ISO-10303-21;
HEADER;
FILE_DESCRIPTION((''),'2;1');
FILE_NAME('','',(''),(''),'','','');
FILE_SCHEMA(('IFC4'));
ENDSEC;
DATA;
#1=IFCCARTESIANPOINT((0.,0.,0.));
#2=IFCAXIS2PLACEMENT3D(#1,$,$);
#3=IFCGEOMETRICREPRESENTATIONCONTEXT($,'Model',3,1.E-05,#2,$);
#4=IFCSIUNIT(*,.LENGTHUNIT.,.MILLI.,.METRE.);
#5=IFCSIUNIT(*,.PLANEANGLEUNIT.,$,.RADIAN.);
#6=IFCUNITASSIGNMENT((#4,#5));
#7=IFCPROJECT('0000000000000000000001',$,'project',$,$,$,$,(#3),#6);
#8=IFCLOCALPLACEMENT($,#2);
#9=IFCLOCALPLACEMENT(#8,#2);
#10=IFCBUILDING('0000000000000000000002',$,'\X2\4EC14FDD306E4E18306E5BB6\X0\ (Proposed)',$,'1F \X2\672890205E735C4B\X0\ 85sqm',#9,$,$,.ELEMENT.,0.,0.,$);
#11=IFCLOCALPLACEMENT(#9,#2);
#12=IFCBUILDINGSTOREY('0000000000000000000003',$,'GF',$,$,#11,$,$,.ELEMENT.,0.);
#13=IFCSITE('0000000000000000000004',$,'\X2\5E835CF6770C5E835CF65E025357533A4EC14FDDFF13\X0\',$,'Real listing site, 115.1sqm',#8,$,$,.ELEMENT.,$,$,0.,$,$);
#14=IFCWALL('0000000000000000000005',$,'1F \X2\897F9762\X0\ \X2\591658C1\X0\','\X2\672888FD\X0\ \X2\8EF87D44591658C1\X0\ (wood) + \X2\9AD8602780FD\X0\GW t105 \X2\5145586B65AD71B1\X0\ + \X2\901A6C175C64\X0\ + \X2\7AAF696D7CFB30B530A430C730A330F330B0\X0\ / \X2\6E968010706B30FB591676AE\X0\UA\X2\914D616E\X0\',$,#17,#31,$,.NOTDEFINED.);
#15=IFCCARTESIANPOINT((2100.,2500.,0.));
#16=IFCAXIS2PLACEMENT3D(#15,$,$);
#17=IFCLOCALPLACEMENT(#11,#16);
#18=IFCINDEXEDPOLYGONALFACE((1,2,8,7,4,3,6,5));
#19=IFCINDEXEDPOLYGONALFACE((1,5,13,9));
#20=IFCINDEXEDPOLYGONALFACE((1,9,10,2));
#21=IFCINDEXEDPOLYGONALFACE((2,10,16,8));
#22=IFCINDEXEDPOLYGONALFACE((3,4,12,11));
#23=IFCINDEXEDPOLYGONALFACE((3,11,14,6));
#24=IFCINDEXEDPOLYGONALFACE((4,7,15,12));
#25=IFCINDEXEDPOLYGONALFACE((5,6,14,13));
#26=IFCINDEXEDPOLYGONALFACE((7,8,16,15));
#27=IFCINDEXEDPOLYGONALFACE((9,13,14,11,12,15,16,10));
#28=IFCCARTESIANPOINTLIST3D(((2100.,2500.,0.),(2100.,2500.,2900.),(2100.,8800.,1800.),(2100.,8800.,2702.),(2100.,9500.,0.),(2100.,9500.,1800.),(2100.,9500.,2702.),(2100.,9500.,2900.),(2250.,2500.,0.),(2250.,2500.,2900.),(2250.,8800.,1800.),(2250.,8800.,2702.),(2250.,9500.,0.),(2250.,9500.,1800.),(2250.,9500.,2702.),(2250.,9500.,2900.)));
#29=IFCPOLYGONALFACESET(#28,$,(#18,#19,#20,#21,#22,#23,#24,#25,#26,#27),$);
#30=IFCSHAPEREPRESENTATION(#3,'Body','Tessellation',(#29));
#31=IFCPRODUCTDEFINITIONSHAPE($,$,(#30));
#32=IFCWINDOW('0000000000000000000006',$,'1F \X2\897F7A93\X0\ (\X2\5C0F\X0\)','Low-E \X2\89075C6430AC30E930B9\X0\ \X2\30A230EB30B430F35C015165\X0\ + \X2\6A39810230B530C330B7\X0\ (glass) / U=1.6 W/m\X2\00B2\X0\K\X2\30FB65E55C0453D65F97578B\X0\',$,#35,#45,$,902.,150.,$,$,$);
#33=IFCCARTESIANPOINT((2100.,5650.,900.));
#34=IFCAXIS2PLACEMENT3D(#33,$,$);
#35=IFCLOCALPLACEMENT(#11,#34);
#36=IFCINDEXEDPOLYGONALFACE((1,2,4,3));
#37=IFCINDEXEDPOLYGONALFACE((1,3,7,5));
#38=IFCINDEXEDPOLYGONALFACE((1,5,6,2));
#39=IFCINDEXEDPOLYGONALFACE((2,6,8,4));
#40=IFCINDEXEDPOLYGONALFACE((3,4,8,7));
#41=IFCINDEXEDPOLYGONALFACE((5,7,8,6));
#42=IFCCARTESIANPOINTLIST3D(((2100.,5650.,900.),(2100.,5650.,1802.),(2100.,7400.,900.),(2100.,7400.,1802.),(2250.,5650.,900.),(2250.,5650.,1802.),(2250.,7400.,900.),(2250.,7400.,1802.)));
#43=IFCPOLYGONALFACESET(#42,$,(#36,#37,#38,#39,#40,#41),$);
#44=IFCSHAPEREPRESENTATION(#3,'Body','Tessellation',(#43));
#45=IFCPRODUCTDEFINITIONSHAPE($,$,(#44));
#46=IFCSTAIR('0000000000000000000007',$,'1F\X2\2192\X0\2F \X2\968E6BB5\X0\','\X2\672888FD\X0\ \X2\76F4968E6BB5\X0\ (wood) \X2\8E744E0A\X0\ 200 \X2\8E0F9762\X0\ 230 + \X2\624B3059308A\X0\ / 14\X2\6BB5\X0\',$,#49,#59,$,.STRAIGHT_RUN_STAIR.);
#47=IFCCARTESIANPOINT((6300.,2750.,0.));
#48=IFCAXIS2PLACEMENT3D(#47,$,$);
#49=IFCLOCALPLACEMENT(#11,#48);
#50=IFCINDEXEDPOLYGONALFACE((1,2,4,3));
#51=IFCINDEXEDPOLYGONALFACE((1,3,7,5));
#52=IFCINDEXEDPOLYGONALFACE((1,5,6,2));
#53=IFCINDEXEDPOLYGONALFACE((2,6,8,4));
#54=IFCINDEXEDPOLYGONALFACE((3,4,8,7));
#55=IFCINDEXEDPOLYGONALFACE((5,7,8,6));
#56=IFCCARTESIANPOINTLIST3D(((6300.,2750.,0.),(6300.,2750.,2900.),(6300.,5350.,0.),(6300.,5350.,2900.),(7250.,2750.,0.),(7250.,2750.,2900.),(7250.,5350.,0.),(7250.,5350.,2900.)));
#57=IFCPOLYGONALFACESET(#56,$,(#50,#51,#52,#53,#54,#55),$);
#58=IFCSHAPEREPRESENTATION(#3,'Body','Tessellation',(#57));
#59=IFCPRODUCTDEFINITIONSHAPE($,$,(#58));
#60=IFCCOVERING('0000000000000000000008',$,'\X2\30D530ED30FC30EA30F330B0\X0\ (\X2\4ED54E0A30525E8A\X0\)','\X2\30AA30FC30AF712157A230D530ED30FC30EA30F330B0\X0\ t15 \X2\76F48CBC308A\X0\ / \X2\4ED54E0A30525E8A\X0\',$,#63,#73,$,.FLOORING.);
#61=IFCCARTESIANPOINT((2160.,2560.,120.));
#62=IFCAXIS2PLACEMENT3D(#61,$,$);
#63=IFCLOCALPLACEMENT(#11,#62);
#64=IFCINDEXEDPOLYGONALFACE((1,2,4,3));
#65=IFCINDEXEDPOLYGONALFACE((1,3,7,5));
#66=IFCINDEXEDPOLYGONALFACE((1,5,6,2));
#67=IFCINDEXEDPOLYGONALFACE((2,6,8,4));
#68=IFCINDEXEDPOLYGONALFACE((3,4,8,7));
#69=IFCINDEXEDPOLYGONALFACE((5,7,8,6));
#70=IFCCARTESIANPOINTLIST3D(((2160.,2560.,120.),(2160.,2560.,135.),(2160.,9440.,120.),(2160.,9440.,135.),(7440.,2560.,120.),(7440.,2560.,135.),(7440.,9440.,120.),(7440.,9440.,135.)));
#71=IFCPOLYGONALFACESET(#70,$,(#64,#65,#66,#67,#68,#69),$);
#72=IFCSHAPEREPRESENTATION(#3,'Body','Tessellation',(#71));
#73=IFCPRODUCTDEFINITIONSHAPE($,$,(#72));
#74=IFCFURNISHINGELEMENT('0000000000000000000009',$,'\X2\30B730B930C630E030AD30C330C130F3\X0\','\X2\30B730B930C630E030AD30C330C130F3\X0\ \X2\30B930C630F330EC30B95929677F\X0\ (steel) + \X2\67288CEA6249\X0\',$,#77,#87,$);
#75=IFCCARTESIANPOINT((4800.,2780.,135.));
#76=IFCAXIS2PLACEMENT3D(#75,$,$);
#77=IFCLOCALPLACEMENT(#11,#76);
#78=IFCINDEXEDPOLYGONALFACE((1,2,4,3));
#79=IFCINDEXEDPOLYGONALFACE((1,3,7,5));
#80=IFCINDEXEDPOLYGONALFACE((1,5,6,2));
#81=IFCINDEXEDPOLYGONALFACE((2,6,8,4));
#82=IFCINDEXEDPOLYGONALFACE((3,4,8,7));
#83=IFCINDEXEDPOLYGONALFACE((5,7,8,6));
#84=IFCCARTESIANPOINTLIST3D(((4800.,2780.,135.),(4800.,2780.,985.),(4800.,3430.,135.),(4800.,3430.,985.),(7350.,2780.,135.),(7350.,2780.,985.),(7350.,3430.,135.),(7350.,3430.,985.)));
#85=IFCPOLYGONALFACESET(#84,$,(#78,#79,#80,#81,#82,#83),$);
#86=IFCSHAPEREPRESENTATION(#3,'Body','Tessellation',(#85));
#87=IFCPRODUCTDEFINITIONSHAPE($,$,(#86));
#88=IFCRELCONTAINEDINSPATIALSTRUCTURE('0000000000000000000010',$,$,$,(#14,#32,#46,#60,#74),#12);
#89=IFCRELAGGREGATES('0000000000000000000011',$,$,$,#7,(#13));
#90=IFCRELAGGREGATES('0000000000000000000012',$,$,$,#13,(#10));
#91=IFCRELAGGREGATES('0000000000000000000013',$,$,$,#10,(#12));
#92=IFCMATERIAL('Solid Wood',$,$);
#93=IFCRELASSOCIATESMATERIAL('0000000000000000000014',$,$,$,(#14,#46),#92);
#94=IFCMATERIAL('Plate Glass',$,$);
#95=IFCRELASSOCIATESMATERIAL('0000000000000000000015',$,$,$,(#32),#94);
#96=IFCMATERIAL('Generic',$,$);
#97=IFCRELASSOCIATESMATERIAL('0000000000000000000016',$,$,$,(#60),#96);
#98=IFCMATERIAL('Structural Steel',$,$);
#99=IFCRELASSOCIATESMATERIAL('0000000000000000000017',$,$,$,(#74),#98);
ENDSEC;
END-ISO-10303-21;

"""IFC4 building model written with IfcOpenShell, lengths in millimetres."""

from ifc_helpers import new_model, si_unit, frame, frame_2d, origin, place, context, project, spatial, rectangle, extrude, material, element, fill, save


model = new_model("IFC4")

# Units and contexts
model_context = context("Model", 3, precision=1e-05, world=origin())
ifc_project = project(units=[si_unit("LENGTHUNIT", "METRE", prefix="MILLI"), si_unit("PLANEANGLEUNIT", "RADIAN")], contexts=[model_context])

# Site, building, storey
site_placement = place(None, origin())
site = spatial("IfcSite", under=ifc_project, at=site_placement, Name="広島県広島市南区仁保３", ObjectType="Real listing site, 115.1sqm", CompositionType="ELEMENT", RefElevation=0.0)
building_placement = place(site_placement, origin())
building = spatial("IfcBuilding", under=site, at=building_placement, Name="仁保の丘の家 (Proposed)", ObjectType="1F 木造平屋 85sqm", CompositionType="ELEMENT", ElevationOfRefHeight=0.0, ElevationOfTerrain=0.0)
storey_placement = place(building_placement, origin())
storey = spatial("IfcBuildingStorey", under=building, at=storey_placement, Name="GF", CompositionType="ELEMENT", Elevation=0.0)

# Shared definitions
ifc_material_1 = material(Name="Solid Wood")
ifc_material_2 = material(Name="Generic")

# Shared definitions
ifc_material_3 = material(Name="Plate Glass")

# Wall, opening, window
wall_1_placement = place(storey_placement, frame((2100.0, 2500.0, 0.0)))
wall_1 = element("IfcWall", 1, at=wall_1_placement, inside=storey, material=ifc_material_1, Name="1F 西面 外壁", Description="木製 軸組外壁 (wood) + 高性能GW t105 充填断熱 + 通気層 + 窯業系サイディング / 準耐火・外皮UA配慮", PredefinedType="NOTDEFINED", context=model_context, shape_type="SweptSolid", body=[
    extrude(rectangle(XDim=150.0, YDim=7000.0, at=frame_2d((75.0, 3500.0))), frame((2100.0, 2500.0, 0.0)), (0.0, 0.0, 1.0), 2900.0),
])
opening_1_placement = place(storey_placement, frame((2100.0, 5650.0, 900.0)))
opening_1 = element("IfcOpeningElement", 2, at=opening_1_placement, cuts=wall_1, PredefinedType="NOTDEFINED", context=model_context, shape_type="SweptSolid", body=[
    extrude(rectangle(XDim=150.0, YDim=1750.0, at=frame_2d((75.0, 875.0))), frame((2100.0, 5650.0, 900.0)), (0.0, 0.0, 1.0), 902.0),
])
window_1_placement = place(storey_placement, frame((2100.0, 5650.0, 900.0)))
window_1 = element("IfcWindow", 3, at=window_1_placement, inside=storey, material=ifc_material_3, Name="1F 西窓 (小)", Description="Low-E 複層ガラス アルゴン封入 + 樹脂サッシ (glass) / U=1.6 W/m²K・日射取得型", OverallHeight=902.0, OverallWidth=150.0, context=model_context, shape_type="SweptSolid", body=[
    extrude(rectangle(XDim=150.0, YDim=1750.0, at=frame_2d((75.0, 875.0))), frame((2100.0, 5650.0, 900.0)), (0.0, 0.0, 1.0), 902.0),
])
fill(opening_1, window_1)

# Stair
stair_placement = place(storey_placement, frame((6300.0, 2750.0, 0.0)))
element("IfcStair", 4, at=stair_placement, inside=storey, material=ifc_material_1, Name="1F→2F 階段", Description="木製 直階段 (wood) 蹴上 200 踏面 230 + 手すり / 14段", PredefinedType="STRAIGHT_RUN_STAIR", context=model_context, shape_type="SweptSolid", body=[
    extrude(rectangle(XDim=950.0, YDim=2600.0, at=frame_2d((475.0, 1300.0))), frame((6300.0, 2750.0, 0.0)), (0.0, 0.0, 1.0), 2900.0),
])

# Covering
covering_placement = place(storey_placement, frame((2160.0, 2560.0, 120.0)))
element("IfcCovering", 5, at=covering_placement, inside=storey, material=ifc_material_2, Name="フローリング (仕上げ床)", Description="オーク無垢フローリング t15 直貼り / 仕上げ床", PredefinedType="FLOORING", context=model_context, shape_type="SweptSolid", body=[
    extrude(rectangle(XDim=5280.0, YDim=6880.0, at=frame_2d((2640.0, 3440.0))), frame((2160.0, 2560.0, 120.0)), (0.0, 0.0, 1.0), 15.0),
])

# Furnishing element
ifc_material_4 = material(Name="Structural Steel")
furnishing_placement = place(storey_placement, frame((4800.0, 2780.0, 135.0)))
element("IfcFurnishingElement", 6, at=furnishing_placement, inside=storey, material=ifc_material_4, Name="システムキッチン", Description="システムキッチン ステンレス天板 (steel) + 木質扉", context=model_context, shape_type="SweptSolid", body=[
    extrude(rectangle(XDim=2550.0, YDim=650.0, at=frame_2d((1275.0, 325.0))), frame((4800.0, 2780.0, 135.0)), (0.0, 0.0, 1.0), 850.0),
])

save(model, "model.ifc")
